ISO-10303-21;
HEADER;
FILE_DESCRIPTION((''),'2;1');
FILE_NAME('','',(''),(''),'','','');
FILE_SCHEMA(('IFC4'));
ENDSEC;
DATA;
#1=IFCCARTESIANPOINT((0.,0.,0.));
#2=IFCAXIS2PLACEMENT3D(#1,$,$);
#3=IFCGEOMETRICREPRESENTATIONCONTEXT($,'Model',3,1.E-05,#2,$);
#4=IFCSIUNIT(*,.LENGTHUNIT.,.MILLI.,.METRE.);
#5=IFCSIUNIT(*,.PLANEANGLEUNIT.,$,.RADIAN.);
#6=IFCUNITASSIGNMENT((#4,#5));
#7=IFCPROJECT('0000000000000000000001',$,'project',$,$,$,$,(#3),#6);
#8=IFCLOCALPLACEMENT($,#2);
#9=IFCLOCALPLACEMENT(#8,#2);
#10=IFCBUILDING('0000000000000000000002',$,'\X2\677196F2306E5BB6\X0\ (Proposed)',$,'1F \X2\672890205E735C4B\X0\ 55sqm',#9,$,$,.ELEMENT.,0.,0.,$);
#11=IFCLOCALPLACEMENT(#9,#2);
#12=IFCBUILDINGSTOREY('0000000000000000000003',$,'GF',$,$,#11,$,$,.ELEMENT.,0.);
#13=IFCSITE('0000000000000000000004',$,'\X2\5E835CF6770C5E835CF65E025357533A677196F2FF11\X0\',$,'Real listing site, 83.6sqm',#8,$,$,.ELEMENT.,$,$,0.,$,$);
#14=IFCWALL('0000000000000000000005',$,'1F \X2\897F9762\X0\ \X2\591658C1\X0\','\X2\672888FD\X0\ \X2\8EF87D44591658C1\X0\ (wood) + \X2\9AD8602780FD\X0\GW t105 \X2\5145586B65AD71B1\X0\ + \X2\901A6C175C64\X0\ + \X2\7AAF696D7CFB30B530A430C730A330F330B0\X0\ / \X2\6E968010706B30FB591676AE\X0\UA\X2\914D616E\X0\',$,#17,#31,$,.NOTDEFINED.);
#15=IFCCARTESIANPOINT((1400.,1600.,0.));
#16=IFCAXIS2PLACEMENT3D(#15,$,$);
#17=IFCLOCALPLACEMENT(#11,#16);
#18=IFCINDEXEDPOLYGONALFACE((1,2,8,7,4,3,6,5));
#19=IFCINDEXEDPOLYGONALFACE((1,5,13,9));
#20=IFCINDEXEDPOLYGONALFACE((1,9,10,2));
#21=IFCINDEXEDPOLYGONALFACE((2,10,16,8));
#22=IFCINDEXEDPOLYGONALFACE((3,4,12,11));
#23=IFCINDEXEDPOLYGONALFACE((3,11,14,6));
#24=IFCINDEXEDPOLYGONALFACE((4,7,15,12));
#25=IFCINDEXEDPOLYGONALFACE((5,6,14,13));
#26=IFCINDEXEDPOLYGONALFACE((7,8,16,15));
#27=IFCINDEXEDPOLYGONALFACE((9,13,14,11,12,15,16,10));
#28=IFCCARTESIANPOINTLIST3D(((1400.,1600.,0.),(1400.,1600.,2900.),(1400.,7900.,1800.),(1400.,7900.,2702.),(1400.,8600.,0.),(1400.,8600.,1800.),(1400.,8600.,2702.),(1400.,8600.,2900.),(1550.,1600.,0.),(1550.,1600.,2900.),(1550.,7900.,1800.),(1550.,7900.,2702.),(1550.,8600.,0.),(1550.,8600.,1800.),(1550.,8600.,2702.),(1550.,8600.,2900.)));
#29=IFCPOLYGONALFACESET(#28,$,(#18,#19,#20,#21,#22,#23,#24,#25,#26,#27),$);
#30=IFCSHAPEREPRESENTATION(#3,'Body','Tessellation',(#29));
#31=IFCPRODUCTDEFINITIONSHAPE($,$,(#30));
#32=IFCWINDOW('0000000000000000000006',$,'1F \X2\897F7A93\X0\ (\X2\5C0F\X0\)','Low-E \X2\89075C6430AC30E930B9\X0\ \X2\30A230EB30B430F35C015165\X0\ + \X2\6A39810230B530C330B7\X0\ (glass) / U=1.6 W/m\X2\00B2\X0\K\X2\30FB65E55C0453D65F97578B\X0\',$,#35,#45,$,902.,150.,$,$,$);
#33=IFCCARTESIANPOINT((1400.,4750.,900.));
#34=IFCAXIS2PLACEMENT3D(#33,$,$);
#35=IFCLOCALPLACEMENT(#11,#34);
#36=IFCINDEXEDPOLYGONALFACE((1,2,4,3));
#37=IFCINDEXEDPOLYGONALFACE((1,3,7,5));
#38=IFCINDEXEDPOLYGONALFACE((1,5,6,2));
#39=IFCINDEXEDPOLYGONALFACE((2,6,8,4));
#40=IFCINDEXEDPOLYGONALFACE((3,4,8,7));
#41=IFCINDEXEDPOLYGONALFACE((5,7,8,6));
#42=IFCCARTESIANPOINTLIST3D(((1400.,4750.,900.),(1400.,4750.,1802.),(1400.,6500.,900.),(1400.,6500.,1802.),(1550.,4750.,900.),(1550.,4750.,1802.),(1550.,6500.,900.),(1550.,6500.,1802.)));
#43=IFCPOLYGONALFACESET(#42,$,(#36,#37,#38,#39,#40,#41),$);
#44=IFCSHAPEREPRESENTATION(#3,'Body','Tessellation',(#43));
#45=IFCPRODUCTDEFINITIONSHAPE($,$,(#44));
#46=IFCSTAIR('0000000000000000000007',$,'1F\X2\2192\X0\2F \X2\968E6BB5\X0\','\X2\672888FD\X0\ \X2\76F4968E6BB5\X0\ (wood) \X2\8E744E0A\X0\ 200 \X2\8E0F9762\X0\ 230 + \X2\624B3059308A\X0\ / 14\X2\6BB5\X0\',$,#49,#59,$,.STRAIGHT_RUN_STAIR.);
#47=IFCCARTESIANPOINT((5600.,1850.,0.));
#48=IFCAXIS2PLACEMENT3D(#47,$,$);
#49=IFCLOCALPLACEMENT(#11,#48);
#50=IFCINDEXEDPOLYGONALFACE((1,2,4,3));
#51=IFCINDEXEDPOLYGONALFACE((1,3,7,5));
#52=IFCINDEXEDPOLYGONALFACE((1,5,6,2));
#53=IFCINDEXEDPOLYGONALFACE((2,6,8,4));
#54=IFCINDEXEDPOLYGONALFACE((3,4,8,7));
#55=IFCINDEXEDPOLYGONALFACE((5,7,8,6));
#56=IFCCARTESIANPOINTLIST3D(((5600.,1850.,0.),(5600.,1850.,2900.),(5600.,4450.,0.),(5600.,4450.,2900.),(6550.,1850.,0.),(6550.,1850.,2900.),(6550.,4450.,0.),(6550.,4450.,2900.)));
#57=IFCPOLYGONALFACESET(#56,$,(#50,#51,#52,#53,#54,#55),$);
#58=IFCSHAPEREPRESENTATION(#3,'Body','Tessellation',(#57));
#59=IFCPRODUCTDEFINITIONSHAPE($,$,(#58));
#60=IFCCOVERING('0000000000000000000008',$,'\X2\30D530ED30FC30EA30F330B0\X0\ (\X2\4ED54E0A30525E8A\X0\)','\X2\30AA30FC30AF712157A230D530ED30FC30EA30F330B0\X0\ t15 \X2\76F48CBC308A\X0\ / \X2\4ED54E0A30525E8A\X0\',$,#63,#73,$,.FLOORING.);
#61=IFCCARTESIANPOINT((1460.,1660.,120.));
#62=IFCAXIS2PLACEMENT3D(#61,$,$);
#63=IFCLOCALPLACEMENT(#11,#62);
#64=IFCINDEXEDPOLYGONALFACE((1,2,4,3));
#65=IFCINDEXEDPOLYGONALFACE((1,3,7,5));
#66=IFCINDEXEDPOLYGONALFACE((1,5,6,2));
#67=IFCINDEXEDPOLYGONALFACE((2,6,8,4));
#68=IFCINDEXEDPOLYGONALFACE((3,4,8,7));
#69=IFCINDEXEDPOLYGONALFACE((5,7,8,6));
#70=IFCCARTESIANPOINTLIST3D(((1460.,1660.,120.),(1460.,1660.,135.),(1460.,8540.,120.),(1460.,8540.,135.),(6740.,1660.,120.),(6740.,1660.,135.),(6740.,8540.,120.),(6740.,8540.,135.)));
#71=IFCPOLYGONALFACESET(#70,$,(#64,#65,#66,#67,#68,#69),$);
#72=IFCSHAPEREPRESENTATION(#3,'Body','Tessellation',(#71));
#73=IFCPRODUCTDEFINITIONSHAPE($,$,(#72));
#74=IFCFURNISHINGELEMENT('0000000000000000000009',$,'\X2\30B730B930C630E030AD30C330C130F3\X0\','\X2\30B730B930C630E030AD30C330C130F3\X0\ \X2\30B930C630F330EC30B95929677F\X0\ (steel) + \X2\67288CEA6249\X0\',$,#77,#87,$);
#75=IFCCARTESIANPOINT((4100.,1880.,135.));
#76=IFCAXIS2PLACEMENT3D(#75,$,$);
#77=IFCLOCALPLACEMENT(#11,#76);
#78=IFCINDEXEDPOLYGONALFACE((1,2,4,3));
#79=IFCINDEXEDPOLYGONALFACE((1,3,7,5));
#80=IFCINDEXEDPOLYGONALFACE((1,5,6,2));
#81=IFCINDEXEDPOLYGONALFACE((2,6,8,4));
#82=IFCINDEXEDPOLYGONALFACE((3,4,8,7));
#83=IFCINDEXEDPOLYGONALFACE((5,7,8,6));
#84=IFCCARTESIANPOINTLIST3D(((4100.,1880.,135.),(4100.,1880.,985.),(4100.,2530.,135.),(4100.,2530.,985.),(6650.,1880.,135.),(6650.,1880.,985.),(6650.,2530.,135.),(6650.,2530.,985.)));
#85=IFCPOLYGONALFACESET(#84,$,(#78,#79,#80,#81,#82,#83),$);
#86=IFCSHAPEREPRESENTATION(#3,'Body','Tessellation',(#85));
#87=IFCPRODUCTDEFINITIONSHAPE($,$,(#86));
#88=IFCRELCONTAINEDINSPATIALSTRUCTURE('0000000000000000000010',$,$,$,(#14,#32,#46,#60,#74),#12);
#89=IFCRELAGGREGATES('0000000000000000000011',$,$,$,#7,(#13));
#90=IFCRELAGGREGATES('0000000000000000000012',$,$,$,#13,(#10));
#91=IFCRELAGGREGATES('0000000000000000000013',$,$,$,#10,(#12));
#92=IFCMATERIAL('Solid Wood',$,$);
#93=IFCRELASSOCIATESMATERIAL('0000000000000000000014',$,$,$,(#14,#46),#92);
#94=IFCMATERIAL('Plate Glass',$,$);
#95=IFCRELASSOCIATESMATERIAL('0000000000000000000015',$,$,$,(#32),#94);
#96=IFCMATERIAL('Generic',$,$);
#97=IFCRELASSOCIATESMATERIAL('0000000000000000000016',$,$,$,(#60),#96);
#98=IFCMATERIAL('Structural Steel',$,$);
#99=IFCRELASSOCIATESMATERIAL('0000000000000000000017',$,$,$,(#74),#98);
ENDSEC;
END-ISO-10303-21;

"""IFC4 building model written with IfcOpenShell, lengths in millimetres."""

from ifc_helpers import new_model, si_unit, frame, frame_2d, origin, place, context, project, spatial, rectangle, extrude, material, element, fill, save


model = new_model("IFC4")

# Units and contexts
model_context = context("Model", 3, precision=1e-05, world=origin())
ifc_project = project(units=[si_unit("LENGTHUNIT", "METRE", prefix="MILLI"), si_unit("PLANEANGLEUNIT", "RADIAN")], contexts=[model_context])

# Site, building, storey
site_placement = place(None, origin())
site = spatial("IfcSite", under=ifc_project, at=site_placement, Name="広島県広島市南区東雲１", ObjectType="Real listing site, 83.6sqm", CompositionType="ELEMENT", RefElevation=0.0)
building_placement = place(site_placement, origin())
building = spatial("IfcBuilding", under=site, at=building_placement, Name="東雲の家 (Proposed)", ObjectType="1F 木造平屋 55sqm", CompositionType="ELEMENT", ElevationOfRefHeight=0.0, ElevationOfTerrain=0.0)
storey_placement = place(building_placement, origin())
storey = spatial("IfcBuildingStorey", under=building, at=storey_placement, Name="GF", CompositionType="ELEMENT", Elevation=0.0)

# Shared definitions
ifc_material_1 = material(Name="Solid Wood")
ifc_material_2 = material(Name="Generic")

# Shared definitions
ifc_material_3 = material(Name="Plate Glass")

# Wall, opening, window
wall_1_placement = place(storey_placement, frame((1400.0, 1600.0, 0.0)))
wall_1 = element("IfcWall", 1, at=wall_1_placement, inside=storey, material=ifc_material_1, Name="1F 西面 外壁", Description="木製 軸組外壁 (wood) + 高性能GW t105 充填断熱 + 通気層 + 窯業系サイディング / 準耐火・外皮UA配慮", PredefinedType="NOTDEFINED", context=model_context, shape_type="SweptSolid", body=[
    extrude(rectangle(XDim=150.0, YDim=7000.0, at=frame_2d((75.0, 3500.0))), frame((1400.0, 1600.0, 0.0)), (0.0, 0.0, 1.0), 2900.0),
])
opening_1_placement = place(storey_placement, frame((1400.0, 4750.0, 900.0)))
opening_1 = element("IfcOpeningElement", 2, at=opening_1_placement, cuts=wall_1, PredefinedType="NOTDEFINED", context=model_context, shape_type="SweptSolid", body=[
    extrude(rectangle(XDim=150.0, YDim=1750.0, at=frame_2d((75.0, 875.0))), frame((1400.0, 4750.0, 900.0)), (0.0, 0.0, 1.0), 902.0),
])
window_1_placement = place(storey_placement, frame((1400.0, 4750.0, 900.0)))
window_1 = element("IfcWindow", 3, at=window_1_placement, inside=storey, material=ifc_material_3, Name="1F 西窓 (小)", Description="Low-E 複層ガラス アルゴン封入 + 樹脂サッシ (glass) / U=1.6 W/m²K・日射取得型", OverallHeight=902.0, OverallWidth=150.0, context=model_context, shape_type="SweptSolid", body=[
    extrude(rectangle(XDim=150.0, YDim=1750.0, at=frame_2d((75.0, 875.0))), frame((1400.0, 4750.0, 900.0)), (0.0, 0.0, 1.0), 902.0),
])
fill(opening_1, window_1)

# Stair
stair_placement = place(storey_placement, frame((5600.0, 1850.0, 0.0)))
element("IfcStair", 4, at=stair_placement, inside=storey, material=ifc_material_1, Name="1F→2F 階段", Description="木製 直階段 (wood) 蹴上 200 踏面 230 + 手すり / 14段", PredefinedType="STRAIGHT_RUN_STAIR", context=model_context, shape_type="SweptSolid", body=[
    extrude(rectangle(XDim=950.0, YDim=2600.0, at=frame_2d((475.0, 1300.0))), frame((5600.0, 1850.0, 0.0)), (0.0, 0.0, 1.0), 2900.0),
])

# Covering
covering_placement = place(storey_placement, frame((1460.0, 1660.0, 120.0)))
element("IfcCovering", 5, at=covering_placement, inside=storey, material=ifc_material_2, Name="フローリング (仕上げ床)", Description="オーク無垢フローリング t15 直貼り / 仕上げ床", PredefinedType="FLOORING", context=model_context, shape_type="SweptSolid", body=[
    extrude(rectangle(XDim=5280.0, YDim=6880.0, at=frame_2d((2640.0, 3440.0))), frame((1460.0, 1660.0, 120.0)), (0.0, 0.0, 1.0), 15.0),
])

# Furnishing element
ifc_material_4 = material(Name="Structural Steel")
furnishing_placement = place(storey_placement, frame((4100.0, 1880.0, 135.0)))
element("IfcFurnishingElement", 6, at=furnishing_placement, inside=storey, material=ifc_material_4, Name="システムキッチン", Description="システムキッチン ステンレス天板 (steel) + 木質扉", context=model_context, shape_type="SweptSolid", body=[
    extrude(rectangle(XDim=2550.0, YDim=650.0, at=frame_2d((1275.0, 325.0))), frame((4100.0, 1880.0, 135.0)), (0.0, 0.0, 1.0), 850.0),
])

save(model, "model.ifc")
